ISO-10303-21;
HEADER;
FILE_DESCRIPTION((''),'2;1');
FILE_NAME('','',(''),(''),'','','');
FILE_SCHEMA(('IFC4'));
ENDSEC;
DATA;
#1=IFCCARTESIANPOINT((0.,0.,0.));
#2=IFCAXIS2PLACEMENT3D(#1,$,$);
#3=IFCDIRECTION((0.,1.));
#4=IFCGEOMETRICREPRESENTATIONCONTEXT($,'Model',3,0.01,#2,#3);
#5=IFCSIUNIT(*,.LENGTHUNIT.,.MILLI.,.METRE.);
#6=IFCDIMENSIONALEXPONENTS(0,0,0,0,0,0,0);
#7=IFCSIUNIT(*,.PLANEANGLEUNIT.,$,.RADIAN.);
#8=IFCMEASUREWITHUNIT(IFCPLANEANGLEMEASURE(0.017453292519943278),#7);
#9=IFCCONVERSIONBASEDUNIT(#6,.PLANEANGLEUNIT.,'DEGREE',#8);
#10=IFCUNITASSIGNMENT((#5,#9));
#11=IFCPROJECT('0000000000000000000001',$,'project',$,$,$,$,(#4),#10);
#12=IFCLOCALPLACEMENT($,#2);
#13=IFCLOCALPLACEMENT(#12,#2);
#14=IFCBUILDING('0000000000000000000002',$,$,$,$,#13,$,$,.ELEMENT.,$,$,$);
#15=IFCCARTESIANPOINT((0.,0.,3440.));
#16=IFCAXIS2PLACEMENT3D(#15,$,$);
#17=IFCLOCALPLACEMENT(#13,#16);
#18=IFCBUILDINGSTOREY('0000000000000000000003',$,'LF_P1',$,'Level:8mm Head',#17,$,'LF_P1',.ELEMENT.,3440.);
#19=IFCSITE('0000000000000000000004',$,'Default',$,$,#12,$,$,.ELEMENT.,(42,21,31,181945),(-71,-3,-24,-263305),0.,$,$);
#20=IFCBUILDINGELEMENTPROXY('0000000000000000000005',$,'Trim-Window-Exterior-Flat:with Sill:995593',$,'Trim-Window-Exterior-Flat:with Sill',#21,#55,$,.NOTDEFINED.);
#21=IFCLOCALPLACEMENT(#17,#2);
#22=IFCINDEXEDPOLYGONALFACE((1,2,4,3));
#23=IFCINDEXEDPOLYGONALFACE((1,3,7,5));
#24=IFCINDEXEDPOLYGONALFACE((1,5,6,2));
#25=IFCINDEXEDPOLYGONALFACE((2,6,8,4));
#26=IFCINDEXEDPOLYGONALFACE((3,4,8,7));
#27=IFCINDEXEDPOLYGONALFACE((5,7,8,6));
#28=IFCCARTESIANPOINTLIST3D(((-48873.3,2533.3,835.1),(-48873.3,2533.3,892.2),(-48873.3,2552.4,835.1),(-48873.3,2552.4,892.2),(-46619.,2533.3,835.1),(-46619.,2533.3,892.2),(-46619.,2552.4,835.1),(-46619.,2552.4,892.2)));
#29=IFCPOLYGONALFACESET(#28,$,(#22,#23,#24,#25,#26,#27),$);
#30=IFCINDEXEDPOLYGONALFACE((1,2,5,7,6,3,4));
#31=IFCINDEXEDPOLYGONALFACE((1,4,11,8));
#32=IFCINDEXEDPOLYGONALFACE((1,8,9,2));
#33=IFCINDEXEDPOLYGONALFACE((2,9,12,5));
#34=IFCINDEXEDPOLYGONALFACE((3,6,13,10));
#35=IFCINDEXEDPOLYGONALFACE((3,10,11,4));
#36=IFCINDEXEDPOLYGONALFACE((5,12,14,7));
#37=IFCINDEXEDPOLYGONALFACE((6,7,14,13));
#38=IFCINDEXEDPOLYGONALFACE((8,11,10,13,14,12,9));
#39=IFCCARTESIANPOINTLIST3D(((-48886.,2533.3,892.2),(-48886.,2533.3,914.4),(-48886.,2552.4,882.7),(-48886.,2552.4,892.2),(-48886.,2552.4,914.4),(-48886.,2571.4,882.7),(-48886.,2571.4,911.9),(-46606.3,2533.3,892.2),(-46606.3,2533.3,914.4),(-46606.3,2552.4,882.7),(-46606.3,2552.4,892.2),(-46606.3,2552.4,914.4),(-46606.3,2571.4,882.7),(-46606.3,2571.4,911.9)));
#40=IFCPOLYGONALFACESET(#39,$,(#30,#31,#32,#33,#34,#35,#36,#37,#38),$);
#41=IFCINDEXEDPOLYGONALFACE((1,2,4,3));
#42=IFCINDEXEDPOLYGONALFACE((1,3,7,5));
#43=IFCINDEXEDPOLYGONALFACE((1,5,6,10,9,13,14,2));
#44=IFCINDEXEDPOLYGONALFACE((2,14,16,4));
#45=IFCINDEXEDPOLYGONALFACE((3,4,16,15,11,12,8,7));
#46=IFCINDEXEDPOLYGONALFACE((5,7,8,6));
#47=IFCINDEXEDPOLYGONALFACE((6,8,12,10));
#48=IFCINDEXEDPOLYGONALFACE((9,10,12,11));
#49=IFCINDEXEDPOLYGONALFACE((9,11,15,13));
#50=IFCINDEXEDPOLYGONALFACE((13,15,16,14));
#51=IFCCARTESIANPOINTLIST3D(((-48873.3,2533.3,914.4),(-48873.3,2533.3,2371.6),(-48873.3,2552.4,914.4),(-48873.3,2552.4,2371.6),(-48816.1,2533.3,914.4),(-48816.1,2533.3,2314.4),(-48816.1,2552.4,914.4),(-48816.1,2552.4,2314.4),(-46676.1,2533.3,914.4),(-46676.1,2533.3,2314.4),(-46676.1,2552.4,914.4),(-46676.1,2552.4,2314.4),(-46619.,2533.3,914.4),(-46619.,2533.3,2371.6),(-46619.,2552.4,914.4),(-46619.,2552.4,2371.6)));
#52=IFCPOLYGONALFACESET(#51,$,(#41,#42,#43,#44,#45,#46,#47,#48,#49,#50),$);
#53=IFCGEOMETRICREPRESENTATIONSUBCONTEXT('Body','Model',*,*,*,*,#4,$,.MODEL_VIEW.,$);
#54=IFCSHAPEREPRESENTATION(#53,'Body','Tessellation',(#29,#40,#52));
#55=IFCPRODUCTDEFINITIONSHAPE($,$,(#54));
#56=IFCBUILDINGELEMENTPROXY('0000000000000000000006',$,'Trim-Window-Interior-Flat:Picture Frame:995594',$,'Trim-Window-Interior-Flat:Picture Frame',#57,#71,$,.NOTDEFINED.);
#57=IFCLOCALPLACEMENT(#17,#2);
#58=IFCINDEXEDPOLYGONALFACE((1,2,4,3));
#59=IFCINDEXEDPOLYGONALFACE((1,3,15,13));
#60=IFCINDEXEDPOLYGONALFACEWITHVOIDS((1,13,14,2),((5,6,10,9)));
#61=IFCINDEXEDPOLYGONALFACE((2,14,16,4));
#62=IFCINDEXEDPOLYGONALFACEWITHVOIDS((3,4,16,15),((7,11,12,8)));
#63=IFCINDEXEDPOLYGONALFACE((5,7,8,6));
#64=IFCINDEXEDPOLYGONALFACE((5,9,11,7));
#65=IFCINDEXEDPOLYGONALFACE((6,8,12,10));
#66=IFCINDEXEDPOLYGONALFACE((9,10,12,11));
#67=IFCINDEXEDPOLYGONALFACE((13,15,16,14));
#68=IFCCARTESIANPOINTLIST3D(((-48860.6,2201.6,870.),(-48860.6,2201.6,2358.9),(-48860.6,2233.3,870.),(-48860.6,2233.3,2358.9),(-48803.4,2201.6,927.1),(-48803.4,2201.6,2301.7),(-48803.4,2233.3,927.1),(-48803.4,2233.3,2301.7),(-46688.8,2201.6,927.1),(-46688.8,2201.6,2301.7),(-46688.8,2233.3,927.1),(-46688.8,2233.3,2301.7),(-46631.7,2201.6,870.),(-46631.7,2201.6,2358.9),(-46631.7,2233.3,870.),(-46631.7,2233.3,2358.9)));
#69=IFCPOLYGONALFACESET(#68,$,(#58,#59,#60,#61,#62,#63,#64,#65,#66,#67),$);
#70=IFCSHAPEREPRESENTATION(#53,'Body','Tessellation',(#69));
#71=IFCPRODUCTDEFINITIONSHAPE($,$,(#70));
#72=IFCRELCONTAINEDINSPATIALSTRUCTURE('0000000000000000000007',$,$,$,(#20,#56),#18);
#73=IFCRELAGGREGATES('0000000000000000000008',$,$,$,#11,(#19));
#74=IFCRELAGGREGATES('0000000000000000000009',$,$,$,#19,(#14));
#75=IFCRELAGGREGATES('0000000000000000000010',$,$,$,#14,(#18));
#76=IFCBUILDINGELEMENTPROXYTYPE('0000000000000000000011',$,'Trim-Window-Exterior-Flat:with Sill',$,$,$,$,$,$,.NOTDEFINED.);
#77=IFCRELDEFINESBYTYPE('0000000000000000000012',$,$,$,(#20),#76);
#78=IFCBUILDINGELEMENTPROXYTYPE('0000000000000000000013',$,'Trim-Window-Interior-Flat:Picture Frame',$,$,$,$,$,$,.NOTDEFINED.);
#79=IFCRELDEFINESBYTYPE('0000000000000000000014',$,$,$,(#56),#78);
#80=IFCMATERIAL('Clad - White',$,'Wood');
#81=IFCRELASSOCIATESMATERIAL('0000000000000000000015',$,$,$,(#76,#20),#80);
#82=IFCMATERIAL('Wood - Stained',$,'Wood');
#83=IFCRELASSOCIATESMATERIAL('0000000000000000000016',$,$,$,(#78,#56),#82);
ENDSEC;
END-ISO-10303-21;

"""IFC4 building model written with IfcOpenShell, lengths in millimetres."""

from ifc_helpers import new_model, entity, si_unit, converted_unit, direction, frame, origin, place, context, subcontext, project, spatial, indexed_curve, outline, extrude, source, transform, mapped, material, type_object, type_shapes, element, save


model = new_model("IFC4")

# Units and contexts
model_context = context("Model", 3, precision=0.01, world=origin(), true_north=direction((0.0, 1.0)))
body_context = subcontext(model_context, "Body", "Model", "MODEL_VIEW")
ifc_project = project(units=[si_unit("LENGTHUNIT", "METRE", prefix="MILLI"), converted_unit("PLANEANGLEUNIT", "DEGREE", entity("IfcPlaneAngleMeasure", 0.017453292519943278), si_unit("PLANEANGLEUNIT", "RADIAN"), dimensions=[0, 0, 0, 0, 0, 0, 0])], contexts=[model_context])

# Site, building, storey
site_placement = place(None, origin())
site = spatial("IfcSite", under=ifc_project, at=site_placement, Name="Default", CompositionType="ELEMENT", RefLatitude=(42, 21, 31, 181945), RefLongitude=(-71, -3, -24, -263305), RefElevation=0.0)
building_placement = place(site_placement, origin())
building = spatial("IfcBuilding", under=site, at=building_placement, CompositionType="ELEMENT")
storey_placement = place(building_placement, frame((0.0, 0.0, 3440.0)))
storey = spatial("IfcBuildingStorey", under=building, at=storey_placement, Name="LF_P1", ObjectType="Level:8mm Head", LongName="LF_P1", CompositionType="ELEMENT", Elevation=3440.0)

# Building element proxies
ifc_material_1 = material(Name="Clad - White", Category="Wood")
ifc_material_2 = material(Name="Wood - Stained", Category="Wood")
building_element_proxy_type_1 = type_object("IfcBuildingElementProxyType", Name="Trim-Window-Exterior-Flat:with Sill", PredefinedType="NOTDEFINED", material=ifc_material_1)
shared_shape_1 = source(origin(), body_context, "Body", "SweptSolid", [
    extrude(outline(indexed_curve([(-1127.1, -28.6), (1127.1, -28.6), (1127.1, 28.6), (-1127.1, 28.6), (-1127.1, -28.6)], self_intersect=False)), frame((0.0, -1450.8, 0.0), z_axis=(0.0, 0.0, 1.0), x_axis=(-1.0, 0.0, 0.0)), (0.0, 0.0, 1.0), 19.0),
    extrude(outline(indexed_curve([(-19.0, -16.0), (0.0, -16.0), (0.0, -6.4), (19.0, -6.4), (19.0, 15.8), (0.0, 15.8), (-19.0, 13.3), (-19.0, -16.0)], self_intersect=False)), frame((-1139.8, -1415.8, 19.0), z_axis=(1.0, 0.0, 0.0), x_axis=(0.0, 0.0, -1.0)), (0.0, 0.0, 1.0), 2279.7),
    extrude(outline(indexed_curve([(-742.9, -1127.1), (714.3, -1127.1), (714.3, -1070.0), (-685.7, -1070.0), (-685.7, 1070.0), (714.3, 1070.0), (714.3, 1127.1), (-742.9, 1127.1), (-742.9, -1127.1)], self_intersect=False)), frame((0.0, -685.7, 0.0), z_axis=(0.0, 0.0, 1.0), x_axis=(0.0, -1.0, 0.0)), (0.0, 0.0, 1.0), 19.0),
])
type_shapes(building_element_proxy_type_1, [shared_shape_1])
proxy_1_placement = place(storey_placement, frame((-47746.1, 2533.3, 2314.4), z_axis=(0.0, 1.0, 0.0), x_axis=(-1.0, 0.0, 0.0)))
element("IfcBuildingElementProxy", 1, at=proxy_1_placement, inside=storey, type_object=building_element_proxy_type_1, material=ifc_material_1, Name="Trim-Window-Exterior-Flat:with Sill:995593", ObjectType="Trim-Window-Exterior-Flat:with Sill", PredefinedType="NOTDEFINED", context=body_context, shape_type="MappedRepresentation", body=[
    mapped(shared_shape_1, transform((0.0, 0.0, 0.0), scale=1.0)),
])
building_element_proxy_type_2 = type_object("IfcBuildingElementProxyType", Name="Trim-Window-Interior-Flat:Picture Frame", PredefinedType="NOTDEFINED", material=ifc_material_2)
shared_shape_2 = source(origin(), body_context, "Body", "SweptSolid", [
    extrude(outline(indexed_curve([(-1114.4, -744.4), (1114.4, -744.4), (1114.4, 744.4), (-1114.4, 744.4), (-1114.4, -744.4)], self_intersect=False), holes=[indexed_curve([(-1057.3, -687.3), (-1057.3, 687.3), (1057.3, 687.3), (1057.3, -687.3), (-1057.3, -687.3)], self_intersect=False)]), frame((0.0, -700.0, 0.0), z_axis=(0.0, 0.0, 1.0), x_axis=(-1.0, 0.0, 0.0)), (0.0, 0.0, 1.0), 31.7),
])
type_shapes(building_element_proxy_type_2, [shared_shape_2])
proxy_2_placement = place(storey_placement, frame((-47746.1, 2233.3, 2314.4), z_axis=(0.0, -1.0, 0.0), x_axis=(1.0, 0.0, 0.0)))
element("IfcBuildingElementProxy", 2, at=proxy_2_placement, inside=storey, type_object=building_element_proxy_type_2, material=ifc_material_2, Name="Trim-Window-Interior-Flat:Picture Frame:995594", ObjectType="Trim-Window-Interior-Flat:Picture Frame", PredefinedType="NOTDEFINED", context=body_context, shape_type="MappedRepresentation", body=[
    mapped(shared_shape_2, transform((0.0, 0.0, 0.0), scale=1.0)),
])

save(model, "model.ifc")
